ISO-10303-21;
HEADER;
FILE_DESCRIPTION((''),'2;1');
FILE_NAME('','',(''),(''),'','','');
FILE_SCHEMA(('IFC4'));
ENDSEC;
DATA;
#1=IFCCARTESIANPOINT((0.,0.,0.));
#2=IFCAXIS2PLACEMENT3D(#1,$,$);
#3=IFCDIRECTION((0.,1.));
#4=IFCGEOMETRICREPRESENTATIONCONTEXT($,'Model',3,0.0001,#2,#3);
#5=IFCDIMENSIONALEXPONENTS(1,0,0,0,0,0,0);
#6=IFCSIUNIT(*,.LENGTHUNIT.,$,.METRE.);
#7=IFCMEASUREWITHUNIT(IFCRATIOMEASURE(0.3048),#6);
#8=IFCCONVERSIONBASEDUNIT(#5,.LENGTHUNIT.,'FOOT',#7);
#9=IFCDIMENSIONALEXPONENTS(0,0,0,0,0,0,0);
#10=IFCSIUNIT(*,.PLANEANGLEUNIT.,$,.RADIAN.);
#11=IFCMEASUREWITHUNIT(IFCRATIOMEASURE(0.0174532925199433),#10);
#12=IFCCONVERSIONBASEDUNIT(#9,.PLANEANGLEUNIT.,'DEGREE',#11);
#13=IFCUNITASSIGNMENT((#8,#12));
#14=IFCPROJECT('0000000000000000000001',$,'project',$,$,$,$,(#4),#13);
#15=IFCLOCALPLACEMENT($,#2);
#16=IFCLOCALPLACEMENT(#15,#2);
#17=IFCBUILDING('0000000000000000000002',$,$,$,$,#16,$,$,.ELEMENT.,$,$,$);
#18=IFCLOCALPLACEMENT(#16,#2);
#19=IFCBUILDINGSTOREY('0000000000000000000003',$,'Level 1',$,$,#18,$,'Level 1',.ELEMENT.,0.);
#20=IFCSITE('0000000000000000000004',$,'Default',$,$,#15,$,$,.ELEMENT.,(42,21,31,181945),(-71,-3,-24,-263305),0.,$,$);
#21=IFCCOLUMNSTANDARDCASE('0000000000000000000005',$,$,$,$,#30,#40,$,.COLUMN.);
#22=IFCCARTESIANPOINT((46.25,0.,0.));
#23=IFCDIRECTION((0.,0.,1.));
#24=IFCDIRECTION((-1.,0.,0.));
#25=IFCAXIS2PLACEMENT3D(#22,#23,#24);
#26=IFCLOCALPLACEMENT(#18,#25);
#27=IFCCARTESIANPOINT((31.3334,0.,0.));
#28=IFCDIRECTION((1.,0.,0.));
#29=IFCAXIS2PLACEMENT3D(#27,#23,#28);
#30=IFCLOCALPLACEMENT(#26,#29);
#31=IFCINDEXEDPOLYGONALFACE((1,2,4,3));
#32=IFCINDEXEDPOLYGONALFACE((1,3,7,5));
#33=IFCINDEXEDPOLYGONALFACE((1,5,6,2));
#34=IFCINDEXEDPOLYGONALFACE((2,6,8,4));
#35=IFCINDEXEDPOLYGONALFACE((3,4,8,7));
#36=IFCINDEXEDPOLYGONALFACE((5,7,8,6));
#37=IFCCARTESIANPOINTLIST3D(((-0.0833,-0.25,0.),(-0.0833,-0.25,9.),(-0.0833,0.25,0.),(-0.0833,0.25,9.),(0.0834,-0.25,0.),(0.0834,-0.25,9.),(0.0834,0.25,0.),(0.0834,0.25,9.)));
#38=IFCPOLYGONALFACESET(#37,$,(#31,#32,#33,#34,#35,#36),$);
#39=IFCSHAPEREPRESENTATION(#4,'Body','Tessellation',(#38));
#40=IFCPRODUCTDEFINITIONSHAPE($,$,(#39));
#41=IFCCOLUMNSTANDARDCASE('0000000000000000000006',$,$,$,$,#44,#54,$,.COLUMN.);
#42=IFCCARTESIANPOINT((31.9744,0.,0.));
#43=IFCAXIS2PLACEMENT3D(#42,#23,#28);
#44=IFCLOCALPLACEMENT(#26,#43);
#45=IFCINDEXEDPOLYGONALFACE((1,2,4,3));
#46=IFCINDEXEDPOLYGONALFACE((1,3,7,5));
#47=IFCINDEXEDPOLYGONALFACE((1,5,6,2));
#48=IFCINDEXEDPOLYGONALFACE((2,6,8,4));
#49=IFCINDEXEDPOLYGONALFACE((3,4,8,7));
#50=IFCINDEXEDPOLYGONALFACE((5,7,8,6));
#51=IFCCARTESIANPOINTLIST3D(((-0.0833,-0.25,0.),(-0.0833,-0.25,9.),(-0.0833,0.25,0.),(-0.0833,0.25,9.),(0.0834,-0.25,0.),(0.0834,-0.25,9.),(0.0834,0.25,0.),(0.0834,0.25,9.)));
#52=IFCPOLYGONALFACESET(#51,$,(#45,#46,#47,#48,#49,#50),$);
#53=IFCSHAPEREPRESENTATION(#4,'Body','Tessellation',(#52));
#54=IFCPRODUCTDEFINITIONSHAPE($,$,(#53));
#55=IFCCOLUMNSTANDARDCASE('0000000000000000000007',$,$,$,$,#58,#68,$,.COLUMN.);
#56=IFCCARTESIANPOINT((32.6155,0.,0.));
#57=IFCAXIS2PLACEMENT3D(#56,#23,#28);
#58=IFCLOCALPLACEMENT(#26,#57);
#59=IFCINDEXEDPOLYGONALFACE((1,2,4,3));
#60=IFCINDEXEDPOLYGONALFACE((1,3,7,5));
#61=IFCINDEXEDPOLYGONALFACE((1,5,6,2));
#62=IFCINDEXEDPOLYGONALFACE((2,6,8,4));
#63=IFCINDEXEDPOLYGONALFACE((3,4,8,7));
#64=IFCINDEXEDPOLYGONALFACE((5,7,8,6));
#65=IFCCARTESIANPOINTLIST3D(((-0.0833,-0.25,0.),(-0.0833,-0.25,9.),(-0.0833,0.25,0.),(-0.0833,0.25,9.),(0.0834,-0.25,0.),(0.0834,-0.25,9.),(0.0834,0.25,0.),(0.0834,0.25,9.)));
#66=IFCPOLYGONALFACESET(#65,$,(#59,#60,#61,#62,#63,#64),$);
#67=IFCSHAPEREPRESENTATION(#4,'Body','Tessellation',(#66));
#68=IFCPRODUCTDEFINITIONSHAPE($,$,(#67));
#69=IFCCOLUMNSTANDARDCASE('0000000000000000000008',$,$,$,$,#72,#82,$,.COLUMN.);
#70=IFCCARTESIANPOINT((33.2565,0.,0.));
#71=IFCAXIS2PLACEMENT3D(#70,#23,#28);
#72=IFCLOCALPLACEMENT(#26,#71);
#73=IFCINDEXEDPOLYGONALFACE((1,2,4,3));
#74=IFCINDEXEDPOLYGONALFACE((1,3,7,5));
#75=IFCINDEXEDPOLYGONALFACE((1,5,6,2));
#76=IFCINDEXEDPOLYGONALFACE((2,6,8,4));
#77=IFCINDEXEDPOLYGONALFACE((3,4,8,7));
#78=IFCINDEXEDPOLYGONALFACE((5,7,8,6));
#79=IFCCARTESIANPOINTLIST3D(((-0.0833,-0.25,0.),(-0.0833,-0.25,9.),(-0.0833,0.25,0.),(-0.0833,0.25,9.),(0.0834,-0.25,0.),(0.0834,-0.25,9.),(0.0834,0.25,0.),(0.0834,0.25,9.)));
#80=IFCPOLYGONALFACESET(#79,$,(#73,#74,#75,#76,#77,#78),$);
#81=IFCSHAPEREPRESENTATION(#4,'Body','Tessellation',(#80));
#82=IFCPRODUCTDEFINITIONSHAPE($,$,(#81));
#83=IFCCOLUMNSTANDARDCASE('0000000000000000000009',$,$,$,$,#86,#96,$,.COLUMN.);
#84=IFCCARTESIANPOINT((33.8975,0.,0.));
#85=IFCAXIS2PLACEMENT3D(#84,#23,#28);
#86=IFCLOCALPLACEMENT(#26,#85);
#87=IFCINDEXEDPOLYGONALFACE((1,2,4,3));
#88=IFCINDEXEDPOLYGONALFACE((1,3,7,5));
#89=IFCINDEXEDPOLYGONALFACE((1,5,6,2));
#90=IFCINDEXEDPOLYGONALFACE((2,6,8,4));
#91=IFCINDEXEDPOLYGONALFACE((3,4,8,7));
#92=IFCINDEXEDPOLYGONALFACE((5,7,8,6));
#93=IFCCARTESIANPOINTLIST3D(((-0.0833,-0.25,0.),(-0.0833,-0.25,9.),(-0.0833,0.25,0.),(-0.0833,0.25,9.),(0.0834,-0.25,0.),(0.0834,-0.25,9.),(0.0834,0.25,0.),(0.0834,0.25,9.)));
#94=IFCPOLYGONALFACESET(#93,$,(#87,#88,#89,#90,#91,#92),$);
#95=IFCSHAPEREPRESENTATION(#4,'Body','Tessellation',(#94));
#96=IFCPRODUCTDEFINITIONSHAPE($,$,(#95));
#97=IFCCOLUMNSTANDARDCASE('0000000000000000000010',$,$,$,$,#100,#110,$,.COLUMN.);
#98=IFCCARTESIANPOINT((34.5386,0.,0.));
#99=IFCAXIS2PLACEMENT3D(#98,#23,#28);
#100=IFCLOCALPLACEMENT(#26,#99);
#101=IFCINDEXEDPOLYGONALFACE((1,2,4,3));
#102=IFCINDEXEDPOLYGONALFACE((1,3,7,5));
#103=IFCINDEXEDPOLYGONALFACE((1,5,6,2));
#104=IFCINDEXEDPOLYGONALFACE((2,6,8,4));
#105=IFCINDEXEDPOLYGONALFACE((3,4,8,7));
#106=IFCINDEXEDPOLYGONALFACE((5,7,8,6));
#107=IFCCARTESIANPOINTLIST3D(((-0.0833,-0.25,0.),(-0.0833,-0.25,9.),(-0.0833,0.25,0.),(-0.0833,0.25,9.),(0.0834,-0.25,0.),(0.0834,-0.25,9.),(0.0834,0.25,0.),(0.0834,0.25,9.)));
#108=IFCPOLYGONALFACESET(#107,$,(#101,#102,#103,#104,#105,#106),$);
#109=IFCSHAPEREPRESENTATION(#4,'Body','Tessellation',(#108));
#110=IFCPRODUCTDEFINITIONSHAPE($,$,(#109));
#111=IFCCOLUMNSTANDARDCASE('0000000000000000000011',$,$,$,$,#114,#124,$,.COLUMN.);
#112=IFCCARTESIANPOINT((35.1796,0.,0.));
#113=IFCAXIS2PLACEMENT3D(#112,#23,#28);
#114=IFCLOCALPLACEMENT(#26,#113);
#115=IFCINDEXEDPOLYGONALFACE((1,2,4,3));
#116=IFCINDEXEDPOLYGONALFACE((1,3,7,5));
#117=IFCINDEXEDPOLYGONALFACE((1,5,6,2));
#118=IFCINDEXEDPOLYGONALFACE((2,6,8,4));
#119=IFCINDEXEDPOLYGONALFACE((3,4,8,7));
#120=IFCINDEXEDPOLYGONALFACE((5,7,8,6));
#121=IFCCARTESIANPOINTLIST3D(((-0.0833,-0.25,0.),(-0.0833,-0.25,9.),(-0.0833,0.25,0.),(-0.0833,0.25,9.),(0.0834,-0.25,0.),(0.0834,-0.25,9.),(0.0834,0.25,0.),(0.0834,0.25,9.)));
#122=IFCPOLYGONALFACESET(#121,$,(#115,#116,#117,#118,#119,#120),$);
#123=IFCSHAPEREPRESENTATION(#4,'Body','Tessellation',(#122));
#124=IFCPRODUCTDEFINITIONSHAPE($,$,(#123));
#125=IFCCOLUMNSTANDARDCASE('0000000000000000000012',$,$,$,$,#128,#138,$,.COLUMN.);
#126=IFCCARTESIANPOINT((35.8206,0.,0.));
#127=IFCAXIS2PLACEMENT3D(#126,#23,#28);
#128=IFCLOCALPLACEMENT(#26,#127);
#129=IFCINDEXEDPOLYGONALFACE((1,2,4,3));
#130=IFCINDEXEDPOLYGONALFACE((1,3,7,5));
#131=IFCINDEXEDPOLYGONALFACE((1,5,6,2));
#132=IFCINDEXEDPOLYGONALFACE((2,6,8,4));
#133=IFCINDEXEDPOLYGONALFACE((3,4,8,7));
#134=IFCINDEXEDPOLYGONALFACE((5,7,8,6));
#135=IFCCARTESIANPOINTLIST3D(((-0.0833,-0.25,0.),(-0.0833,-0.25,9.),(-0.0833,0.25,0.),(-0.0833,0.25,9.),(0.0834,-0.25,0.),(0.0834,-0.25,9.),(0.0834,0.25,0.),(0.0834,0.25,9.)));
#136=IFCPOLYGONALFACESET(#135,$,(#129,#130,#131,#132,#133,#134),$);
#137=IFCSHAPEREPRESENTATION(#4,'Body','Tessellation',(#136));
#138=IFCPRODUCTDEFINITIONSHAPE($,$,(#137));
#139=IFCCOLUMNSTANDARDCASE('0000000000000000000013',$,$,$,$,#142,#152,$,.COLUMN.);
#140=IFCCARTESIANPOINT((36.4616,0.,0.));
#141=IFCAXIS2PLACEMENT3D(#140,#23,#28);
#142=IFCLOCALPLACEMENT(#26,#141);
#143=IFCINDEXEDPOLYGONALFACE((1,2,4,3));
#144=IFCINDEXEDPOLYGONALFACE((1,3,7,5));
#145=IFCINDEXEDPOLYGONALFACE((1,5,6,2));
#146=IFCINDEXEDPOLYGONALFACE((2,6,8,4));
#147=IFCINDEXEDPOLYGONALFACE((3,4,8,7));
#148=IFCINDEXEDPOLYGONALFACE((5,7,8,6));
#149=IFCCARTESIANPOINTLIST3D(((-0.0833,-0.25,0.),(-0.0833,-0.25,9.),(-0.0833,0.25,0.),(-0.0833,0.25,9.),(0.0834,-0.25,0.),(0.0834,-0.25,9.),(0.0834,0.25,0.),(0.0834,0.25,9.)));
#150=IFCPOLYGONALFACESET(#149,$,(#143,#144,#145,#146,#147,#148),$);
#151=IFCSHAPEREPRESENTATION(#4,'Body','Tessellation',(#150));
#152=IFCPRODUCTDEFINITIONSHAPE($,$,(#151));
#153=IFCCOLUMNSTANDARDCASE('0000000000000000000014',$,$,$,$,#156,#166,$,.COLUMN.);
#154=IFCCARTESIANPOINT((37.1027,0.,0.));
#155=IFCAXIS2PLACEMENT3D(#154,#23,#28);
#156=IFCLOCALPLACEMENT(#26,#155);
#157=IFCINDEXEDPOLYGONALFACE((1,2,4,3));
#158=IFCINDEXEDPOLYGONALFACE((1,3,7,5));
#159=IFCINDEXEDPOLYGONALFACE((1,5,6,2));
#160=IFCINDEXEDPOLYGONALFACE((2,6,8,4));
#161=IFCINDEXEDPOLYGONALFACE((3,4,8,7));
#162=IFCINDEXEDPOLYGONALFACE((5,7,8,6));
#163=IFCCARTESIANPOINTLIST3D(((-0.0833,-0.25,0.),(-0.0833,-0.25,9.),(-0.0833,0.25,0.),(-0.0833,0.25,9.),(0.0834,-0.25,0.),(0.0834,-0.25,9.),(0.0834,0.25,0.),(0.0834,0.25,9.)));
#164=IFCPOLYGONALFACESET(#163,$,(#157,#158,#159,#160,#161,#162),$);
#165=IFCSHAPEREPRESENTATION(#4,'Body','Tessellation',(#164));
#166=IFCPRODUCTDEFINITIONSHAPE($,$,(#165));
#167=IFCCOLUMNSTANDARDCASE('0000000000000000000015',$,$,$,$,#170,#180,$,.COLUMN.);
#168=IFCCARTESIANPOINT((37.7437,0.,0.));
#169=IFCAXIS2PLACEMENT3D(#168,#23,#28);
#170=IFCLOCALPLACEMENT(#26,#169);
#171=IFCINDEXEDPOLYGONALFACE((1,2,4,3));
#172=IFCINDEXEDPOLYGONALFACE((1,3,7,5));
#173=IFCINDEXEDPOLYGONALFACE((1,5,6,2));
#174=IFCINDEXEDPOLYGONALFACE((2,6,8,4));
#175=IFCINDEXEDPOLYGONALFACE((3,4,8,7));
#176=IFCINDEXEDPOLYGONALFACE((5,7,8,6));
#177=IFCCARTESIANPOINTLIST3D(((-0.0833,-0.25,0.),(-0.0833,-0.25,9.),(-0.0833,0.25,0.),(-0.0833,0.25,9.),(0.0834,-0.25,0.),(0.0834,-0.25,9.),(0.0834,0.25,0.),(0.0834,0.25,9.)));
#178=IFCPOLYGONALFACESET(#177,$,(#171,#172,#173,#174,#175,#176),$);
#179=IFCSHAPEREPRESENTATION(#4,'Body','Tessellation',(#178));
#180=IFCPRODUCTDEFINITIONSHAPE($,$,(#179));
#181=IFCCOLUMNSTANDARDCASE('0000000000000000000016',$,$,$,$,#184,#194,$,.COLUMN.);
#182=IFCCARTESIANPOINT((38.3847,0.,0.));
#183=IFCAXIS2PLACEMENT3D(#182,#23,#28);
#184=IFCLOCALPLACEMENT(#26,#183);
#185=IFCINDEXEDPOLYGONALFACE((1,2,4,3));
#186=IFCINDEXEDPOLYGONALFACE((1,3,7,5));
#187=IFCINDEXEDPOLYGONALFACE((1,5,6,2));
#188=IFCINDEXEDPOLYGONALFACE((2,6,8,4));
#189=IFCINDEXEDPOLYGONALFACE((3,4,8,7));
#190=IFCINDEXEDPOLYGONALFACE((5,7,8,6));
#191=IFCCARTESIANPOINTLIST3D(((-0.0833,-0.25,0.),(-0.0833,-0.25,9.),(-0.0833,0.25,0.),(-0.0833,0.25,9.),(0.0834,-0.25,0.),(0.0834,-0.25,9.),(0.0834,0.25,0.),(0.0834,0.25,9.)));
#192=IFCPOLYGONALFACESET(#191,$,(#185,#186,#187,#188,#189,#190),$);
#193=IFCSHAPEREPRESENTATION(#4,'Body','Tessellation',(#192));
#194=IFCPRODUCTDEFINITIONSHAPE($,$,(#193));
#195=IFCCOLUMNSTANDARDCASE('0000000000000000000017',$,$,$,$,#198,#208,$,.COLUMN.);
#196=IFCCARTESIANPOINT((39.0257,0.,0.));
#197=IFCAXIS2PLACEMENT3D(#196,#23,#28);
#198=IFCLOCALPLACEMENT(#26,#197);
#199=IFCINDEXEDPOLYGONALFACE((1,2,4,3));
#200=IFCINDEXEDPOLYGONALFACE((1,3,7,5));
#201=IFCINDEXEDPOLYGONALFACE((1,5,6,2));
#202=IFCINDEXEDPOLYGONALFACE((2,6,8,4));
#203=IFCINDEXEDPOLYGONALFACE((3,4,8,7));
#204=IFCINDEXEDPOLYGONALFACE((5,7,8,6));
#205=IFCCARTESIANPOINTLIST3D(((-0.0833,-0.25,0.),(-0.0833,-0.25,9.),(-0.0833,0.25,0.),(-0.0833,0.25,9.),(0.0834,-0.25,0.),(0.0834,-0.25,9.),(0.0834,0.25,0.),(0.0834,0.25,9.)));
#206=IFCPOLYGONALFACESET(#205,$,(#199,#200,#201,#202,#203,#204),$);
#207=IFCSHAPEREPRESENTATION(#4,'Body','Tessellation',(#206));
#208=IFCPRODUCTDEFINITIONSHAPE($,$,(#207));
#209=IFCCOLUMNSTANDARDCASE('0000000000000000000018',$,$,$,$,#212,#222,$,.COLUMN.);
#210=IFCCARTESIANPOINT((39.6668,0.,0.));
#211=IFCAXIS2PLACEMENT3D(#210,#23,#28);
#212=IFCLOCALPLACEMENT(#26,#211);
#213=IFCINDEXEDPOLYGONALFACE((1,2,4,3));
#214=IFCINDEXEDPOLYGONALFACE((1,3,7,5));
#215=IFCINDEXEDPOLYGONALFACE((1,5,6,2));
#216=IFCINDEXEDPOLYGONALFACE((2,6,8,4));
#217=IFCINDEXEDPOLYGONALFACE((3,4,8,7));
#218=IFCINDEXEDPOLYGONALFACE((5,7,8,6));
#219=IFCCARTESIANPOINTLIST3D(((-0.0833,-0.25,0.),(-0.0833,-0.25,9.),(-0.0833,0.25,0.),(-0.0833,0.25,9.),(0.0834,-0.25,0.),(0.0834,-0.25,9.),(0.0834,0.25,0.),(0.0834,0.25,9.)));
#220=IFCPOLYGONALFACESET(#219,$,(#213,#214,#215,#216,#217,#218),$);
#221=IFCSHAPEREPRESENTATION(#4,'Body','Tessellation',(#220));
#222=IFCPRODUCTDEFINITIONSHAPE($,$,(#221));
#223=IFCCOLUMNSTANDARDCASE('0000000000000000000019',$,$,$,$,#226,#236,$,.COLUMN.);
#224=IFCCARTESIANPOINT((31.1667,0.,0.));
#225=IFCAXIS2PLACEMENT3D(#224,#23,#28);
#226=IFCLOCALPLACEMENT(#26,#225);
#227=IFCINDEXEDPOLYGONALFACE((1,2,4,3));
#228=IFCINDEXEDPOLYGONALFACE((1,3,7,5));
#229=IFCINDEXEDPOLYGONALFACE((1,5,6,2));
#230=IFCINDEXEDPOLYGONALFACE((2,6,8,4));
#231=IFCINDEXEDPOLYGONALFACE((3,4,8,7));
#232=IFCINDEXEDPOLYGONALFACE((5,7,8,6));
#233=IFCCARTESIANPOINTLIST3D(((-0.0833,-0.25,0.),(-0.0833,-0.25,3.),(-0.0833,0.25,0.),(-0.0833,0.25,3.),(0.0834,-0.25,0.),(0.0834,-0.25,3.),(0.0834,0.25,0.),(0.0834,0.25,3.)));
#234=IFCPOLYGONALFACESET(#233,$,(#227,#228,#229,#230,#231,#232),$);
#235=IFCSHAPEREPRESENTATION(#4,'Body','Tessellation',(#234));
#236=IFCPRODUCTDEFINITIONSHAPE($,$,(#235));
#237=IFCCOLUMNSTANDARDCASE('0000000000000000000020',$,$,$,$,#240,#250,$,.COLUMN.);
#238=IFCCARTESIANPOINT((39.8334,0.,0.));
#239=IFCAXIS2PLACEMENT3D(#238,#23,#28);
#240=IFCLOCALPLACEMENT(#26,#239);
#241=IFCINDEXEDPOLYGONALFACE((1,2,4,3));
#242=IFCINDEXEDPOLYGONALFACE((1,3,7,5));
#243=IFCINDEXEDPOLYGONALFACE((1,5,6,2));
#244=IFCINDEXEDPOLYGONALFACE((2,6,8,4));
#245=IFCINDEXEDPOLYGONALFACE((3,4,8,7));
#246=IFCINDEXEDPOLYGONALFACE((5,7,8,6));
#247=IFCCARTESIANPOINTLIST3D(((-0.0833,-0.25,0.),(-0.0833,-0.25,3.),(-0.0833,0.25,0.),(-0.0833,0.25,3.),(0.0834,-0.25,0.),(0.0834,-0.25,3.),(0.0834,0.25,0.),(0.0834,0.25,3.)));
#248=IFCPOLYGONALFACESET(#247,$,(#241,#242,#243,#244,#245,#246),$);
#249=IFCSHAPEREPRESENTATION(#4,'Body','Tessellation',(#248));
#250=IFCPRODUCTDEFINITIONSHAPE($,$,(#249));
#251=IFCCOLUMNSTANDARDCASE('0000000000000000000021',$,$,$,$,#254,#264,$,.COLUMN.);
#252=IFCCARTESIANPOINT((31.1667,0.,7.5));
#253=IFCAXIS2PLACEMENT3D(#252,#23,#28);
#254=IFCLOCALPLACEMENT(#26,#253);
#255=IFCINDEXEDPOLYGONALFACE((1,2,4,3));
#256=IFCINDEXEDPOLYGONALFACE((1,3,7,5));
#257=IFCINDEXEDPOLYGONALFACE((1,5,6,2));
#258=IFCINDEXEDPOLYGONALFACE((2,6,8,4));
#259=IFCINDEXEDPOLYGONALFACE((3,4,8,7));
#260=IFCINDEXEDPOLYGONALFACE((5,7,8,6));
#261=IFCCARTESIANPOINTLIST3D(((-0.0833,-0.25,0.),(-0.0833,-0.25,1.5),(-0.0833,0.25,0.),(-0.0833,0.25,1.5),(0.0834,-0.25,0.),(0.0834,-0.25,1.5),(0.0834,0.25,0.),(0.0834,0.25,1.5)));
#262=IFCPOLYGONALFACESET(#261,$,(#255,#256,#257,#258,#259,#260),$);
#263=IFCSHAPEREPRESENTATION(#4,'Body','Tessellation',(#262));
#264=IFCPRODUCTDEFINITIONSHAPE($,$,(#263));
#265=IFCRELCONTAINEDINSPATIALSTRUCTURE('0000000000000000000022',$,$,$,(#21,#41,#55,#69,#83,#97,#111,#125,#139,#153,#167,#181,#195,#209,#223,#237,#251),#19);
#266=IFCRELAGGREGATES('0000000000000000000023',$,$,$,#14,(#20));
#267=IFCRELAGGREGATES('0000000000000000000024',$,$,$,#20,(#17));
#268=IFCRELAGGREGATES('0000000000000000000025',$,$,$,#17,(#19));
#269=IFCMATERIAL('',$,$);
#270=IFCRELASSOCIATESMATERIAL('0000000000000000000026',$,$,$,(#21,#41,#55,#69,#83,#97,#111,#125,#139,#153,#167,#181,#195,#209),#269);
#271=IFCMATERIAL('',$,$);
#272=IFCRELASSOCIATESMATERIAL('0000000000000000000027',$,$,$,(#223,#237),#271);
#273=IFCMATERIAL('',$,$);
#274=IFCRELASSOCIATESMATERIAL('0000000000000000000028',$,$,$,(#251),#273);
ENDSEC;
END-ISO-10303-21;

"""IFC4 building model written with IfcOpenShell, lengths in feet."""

from ifc_helpers import new_model, entity, si_unit, converted_unit, direction, frame, origin, place, context, project, spatial, rectangle, extrude, material, element, save


model = new_model("IFC4")

# Units and contexts
model_context = context("Model", 3, precision=0.0001, world=origin(), true_north=direction((0.0, 1.0)))
ifc_project = project(units=[converted_unit("LENGTHUNIT", "FOOT", entity("IfcRatioMeasure", 0.3048), si_unit("LENGTHUNIT", "METRE"), dimensions=[1, 0, 0, 0, 0, 0, 0]), converted_unit("PLANEANGLEUNIT", "DEGREE", entity("IfcRatioMeasure", 0.0174532925199433), si_unit("PLANEANGLEUNIT", "RADIAN"), dimensions=[0, 0, 0, 0, 0, 0, 0])], contexts=[model_context])

# Site, building, storey
site_placement = place(None, origin())
site = spatial("IfcSite", under=ifc_project, at=site_placement, Name="Default", CompositionType="ELEMENT", RefLatitude=(42, 21, 31, 181945), RefLongitude=(-71, -3, -24, -263305), RefElevation=0.0)
building_placement = place(site_placement, origin())
building = spatial("IfcBuilding", under=site, at=building_placement, CompositionType="ELEMENT")
storey_placement = place(building_placement, origin())
storey = spatial("IfcBuildingStorey", under=building, at=storey_placement, Name="Level 1", LongName="Level 1", CompositionType="ELEMENT", Elevation=0.0)

# Columns
ifc_material_1 = material(Name="")
placement_1 = place(storey_placement, frame((46.25, 0.0, 0.0), z_axis=(0.0, 0.0, 1.0), x_axis=(-1.0, 0.0, 0.0)))
for number, where, z_axis, x_axis in (
    (1, (31.3334, 0.0, 0.0), (0.0, 0.0, 1.0), (1.0, 0.0, 0.0)),
    (2, (31.9744, 0.0, 0.0), (0.0, 0.0, 1.0), (1.0, 0.0, 0.0)),
    (3, (32.6155, 0.0, 0.0), (0.0, 0.0, 1.0), (1.0, 0.0, 0.0)),
    (4, (33.2565, 0.0, 0.0), (0.0, 0.0, 1.0), (1.0, 0.0, 0.0)),
    (5, (33.8975, 0.0, 0.0), (0.0, 0.0, 1.0), (1.0, 0.0, 0.0)),
    (6, (34.5386, 0.0, 0.0), (0.0, 0.0, 1.0), (1.0, 0.0, 0.0)),
    (7, (35.1796, 0.0, 0.0), (0.0, 0.0, 1.0), (1.0, 0.0, 0.0)),
    (8, (35.8206, 0.0, 0.0), (0.0, 0.0, 1.0), (1.0, 0.0, 0.0)),
    (9, (36.4616, 0.0, 0.0), (0.0, 0.0, 1.0), (1.0, 0.0, 0.0)),
    (10, (37.1027, 0.0, 0.0), (0.0, 0.0, 1.0), (1.0, 0.0, 0.0)),
    (11, (37.7437, 0.0, 0.0), (0.0, 0.0, 1.0), (1.0, 0.0, 0.0)),
    (12, (38.3847, 0.0, 0.0), (0.0, 0.0, 1.0), (1.0, 0.0, 0.0)),
    (13, (39.0257, 0.0, 0.0), (0.0, 0.0, 1.0), (1.0, 0.0, 0.0)),
    (14, (39.6668, 0.0, 0.0), (0.0, 0.0, 1.0), (1.0, 0.0, 0.0)),
):
    element("IfcColumnStandardCase", number, at=place(placement_1, frame(where, z_axis=z_axis, x_axis=x_axis)), inside=storey, material=ifc_material_1, PredefinedType="COLUMN", context=model_context, shape_type="SweptSolid", body=[
        extrude(rectangle(XDim=0.1667, YDim=0.5), origin(), (0.0, 0.0, 1.0), 9.0),
    ])
ifc_material_2 = material(Name="")
for number, where, z_axis, x_axis in (
    (15, (31.1667, 0.0, 0.0), (0.0, 0.0, 1.0), (1.0, 0.0, 0.0)),
    (16, (39.8334, 0.0, 0.0), (0.0, 0.0, 1.0), (1.0, 0.0, 0.0)),
):
    element("IfcColumnStandardCase", number, at=place(placement_1, frame(where, z_axis=z_axis, x_axis=x_axis)), inside=storey, material=ifc_material_2, PredefinedType="COLUMN", context=model_context, shape_type="SweptSolid", body=[
        extrude(rectangle(XDim=0.1667, YDim=0.5), origin(), (0.0, 0.0, 1.0), 3.0),
    ])
ifc_material_3 = material(Name="")
for number, where, z_axis, x_axis in (
    (17, (31.1667, 0.0, 7.5), (0.0, 0.0, 1.0), (1.0, 0.0, 0.0)),
):
    element("IfcColumnStandardCase", number, at=place(placement_1, frame(where, z_axis=z_axis, x_axis=x_axis)), inside=storey, material=ifc_material_3, PredefinedType="COLUMN", context=model_context, shape_type="SweptSolid", body=[
        extrude(rectangle(XDim=0.1667, YDim=0.5), origin(), (0.0, 0.0, 1.0), 1.5),
    ])

save(model, "model.ifc")
